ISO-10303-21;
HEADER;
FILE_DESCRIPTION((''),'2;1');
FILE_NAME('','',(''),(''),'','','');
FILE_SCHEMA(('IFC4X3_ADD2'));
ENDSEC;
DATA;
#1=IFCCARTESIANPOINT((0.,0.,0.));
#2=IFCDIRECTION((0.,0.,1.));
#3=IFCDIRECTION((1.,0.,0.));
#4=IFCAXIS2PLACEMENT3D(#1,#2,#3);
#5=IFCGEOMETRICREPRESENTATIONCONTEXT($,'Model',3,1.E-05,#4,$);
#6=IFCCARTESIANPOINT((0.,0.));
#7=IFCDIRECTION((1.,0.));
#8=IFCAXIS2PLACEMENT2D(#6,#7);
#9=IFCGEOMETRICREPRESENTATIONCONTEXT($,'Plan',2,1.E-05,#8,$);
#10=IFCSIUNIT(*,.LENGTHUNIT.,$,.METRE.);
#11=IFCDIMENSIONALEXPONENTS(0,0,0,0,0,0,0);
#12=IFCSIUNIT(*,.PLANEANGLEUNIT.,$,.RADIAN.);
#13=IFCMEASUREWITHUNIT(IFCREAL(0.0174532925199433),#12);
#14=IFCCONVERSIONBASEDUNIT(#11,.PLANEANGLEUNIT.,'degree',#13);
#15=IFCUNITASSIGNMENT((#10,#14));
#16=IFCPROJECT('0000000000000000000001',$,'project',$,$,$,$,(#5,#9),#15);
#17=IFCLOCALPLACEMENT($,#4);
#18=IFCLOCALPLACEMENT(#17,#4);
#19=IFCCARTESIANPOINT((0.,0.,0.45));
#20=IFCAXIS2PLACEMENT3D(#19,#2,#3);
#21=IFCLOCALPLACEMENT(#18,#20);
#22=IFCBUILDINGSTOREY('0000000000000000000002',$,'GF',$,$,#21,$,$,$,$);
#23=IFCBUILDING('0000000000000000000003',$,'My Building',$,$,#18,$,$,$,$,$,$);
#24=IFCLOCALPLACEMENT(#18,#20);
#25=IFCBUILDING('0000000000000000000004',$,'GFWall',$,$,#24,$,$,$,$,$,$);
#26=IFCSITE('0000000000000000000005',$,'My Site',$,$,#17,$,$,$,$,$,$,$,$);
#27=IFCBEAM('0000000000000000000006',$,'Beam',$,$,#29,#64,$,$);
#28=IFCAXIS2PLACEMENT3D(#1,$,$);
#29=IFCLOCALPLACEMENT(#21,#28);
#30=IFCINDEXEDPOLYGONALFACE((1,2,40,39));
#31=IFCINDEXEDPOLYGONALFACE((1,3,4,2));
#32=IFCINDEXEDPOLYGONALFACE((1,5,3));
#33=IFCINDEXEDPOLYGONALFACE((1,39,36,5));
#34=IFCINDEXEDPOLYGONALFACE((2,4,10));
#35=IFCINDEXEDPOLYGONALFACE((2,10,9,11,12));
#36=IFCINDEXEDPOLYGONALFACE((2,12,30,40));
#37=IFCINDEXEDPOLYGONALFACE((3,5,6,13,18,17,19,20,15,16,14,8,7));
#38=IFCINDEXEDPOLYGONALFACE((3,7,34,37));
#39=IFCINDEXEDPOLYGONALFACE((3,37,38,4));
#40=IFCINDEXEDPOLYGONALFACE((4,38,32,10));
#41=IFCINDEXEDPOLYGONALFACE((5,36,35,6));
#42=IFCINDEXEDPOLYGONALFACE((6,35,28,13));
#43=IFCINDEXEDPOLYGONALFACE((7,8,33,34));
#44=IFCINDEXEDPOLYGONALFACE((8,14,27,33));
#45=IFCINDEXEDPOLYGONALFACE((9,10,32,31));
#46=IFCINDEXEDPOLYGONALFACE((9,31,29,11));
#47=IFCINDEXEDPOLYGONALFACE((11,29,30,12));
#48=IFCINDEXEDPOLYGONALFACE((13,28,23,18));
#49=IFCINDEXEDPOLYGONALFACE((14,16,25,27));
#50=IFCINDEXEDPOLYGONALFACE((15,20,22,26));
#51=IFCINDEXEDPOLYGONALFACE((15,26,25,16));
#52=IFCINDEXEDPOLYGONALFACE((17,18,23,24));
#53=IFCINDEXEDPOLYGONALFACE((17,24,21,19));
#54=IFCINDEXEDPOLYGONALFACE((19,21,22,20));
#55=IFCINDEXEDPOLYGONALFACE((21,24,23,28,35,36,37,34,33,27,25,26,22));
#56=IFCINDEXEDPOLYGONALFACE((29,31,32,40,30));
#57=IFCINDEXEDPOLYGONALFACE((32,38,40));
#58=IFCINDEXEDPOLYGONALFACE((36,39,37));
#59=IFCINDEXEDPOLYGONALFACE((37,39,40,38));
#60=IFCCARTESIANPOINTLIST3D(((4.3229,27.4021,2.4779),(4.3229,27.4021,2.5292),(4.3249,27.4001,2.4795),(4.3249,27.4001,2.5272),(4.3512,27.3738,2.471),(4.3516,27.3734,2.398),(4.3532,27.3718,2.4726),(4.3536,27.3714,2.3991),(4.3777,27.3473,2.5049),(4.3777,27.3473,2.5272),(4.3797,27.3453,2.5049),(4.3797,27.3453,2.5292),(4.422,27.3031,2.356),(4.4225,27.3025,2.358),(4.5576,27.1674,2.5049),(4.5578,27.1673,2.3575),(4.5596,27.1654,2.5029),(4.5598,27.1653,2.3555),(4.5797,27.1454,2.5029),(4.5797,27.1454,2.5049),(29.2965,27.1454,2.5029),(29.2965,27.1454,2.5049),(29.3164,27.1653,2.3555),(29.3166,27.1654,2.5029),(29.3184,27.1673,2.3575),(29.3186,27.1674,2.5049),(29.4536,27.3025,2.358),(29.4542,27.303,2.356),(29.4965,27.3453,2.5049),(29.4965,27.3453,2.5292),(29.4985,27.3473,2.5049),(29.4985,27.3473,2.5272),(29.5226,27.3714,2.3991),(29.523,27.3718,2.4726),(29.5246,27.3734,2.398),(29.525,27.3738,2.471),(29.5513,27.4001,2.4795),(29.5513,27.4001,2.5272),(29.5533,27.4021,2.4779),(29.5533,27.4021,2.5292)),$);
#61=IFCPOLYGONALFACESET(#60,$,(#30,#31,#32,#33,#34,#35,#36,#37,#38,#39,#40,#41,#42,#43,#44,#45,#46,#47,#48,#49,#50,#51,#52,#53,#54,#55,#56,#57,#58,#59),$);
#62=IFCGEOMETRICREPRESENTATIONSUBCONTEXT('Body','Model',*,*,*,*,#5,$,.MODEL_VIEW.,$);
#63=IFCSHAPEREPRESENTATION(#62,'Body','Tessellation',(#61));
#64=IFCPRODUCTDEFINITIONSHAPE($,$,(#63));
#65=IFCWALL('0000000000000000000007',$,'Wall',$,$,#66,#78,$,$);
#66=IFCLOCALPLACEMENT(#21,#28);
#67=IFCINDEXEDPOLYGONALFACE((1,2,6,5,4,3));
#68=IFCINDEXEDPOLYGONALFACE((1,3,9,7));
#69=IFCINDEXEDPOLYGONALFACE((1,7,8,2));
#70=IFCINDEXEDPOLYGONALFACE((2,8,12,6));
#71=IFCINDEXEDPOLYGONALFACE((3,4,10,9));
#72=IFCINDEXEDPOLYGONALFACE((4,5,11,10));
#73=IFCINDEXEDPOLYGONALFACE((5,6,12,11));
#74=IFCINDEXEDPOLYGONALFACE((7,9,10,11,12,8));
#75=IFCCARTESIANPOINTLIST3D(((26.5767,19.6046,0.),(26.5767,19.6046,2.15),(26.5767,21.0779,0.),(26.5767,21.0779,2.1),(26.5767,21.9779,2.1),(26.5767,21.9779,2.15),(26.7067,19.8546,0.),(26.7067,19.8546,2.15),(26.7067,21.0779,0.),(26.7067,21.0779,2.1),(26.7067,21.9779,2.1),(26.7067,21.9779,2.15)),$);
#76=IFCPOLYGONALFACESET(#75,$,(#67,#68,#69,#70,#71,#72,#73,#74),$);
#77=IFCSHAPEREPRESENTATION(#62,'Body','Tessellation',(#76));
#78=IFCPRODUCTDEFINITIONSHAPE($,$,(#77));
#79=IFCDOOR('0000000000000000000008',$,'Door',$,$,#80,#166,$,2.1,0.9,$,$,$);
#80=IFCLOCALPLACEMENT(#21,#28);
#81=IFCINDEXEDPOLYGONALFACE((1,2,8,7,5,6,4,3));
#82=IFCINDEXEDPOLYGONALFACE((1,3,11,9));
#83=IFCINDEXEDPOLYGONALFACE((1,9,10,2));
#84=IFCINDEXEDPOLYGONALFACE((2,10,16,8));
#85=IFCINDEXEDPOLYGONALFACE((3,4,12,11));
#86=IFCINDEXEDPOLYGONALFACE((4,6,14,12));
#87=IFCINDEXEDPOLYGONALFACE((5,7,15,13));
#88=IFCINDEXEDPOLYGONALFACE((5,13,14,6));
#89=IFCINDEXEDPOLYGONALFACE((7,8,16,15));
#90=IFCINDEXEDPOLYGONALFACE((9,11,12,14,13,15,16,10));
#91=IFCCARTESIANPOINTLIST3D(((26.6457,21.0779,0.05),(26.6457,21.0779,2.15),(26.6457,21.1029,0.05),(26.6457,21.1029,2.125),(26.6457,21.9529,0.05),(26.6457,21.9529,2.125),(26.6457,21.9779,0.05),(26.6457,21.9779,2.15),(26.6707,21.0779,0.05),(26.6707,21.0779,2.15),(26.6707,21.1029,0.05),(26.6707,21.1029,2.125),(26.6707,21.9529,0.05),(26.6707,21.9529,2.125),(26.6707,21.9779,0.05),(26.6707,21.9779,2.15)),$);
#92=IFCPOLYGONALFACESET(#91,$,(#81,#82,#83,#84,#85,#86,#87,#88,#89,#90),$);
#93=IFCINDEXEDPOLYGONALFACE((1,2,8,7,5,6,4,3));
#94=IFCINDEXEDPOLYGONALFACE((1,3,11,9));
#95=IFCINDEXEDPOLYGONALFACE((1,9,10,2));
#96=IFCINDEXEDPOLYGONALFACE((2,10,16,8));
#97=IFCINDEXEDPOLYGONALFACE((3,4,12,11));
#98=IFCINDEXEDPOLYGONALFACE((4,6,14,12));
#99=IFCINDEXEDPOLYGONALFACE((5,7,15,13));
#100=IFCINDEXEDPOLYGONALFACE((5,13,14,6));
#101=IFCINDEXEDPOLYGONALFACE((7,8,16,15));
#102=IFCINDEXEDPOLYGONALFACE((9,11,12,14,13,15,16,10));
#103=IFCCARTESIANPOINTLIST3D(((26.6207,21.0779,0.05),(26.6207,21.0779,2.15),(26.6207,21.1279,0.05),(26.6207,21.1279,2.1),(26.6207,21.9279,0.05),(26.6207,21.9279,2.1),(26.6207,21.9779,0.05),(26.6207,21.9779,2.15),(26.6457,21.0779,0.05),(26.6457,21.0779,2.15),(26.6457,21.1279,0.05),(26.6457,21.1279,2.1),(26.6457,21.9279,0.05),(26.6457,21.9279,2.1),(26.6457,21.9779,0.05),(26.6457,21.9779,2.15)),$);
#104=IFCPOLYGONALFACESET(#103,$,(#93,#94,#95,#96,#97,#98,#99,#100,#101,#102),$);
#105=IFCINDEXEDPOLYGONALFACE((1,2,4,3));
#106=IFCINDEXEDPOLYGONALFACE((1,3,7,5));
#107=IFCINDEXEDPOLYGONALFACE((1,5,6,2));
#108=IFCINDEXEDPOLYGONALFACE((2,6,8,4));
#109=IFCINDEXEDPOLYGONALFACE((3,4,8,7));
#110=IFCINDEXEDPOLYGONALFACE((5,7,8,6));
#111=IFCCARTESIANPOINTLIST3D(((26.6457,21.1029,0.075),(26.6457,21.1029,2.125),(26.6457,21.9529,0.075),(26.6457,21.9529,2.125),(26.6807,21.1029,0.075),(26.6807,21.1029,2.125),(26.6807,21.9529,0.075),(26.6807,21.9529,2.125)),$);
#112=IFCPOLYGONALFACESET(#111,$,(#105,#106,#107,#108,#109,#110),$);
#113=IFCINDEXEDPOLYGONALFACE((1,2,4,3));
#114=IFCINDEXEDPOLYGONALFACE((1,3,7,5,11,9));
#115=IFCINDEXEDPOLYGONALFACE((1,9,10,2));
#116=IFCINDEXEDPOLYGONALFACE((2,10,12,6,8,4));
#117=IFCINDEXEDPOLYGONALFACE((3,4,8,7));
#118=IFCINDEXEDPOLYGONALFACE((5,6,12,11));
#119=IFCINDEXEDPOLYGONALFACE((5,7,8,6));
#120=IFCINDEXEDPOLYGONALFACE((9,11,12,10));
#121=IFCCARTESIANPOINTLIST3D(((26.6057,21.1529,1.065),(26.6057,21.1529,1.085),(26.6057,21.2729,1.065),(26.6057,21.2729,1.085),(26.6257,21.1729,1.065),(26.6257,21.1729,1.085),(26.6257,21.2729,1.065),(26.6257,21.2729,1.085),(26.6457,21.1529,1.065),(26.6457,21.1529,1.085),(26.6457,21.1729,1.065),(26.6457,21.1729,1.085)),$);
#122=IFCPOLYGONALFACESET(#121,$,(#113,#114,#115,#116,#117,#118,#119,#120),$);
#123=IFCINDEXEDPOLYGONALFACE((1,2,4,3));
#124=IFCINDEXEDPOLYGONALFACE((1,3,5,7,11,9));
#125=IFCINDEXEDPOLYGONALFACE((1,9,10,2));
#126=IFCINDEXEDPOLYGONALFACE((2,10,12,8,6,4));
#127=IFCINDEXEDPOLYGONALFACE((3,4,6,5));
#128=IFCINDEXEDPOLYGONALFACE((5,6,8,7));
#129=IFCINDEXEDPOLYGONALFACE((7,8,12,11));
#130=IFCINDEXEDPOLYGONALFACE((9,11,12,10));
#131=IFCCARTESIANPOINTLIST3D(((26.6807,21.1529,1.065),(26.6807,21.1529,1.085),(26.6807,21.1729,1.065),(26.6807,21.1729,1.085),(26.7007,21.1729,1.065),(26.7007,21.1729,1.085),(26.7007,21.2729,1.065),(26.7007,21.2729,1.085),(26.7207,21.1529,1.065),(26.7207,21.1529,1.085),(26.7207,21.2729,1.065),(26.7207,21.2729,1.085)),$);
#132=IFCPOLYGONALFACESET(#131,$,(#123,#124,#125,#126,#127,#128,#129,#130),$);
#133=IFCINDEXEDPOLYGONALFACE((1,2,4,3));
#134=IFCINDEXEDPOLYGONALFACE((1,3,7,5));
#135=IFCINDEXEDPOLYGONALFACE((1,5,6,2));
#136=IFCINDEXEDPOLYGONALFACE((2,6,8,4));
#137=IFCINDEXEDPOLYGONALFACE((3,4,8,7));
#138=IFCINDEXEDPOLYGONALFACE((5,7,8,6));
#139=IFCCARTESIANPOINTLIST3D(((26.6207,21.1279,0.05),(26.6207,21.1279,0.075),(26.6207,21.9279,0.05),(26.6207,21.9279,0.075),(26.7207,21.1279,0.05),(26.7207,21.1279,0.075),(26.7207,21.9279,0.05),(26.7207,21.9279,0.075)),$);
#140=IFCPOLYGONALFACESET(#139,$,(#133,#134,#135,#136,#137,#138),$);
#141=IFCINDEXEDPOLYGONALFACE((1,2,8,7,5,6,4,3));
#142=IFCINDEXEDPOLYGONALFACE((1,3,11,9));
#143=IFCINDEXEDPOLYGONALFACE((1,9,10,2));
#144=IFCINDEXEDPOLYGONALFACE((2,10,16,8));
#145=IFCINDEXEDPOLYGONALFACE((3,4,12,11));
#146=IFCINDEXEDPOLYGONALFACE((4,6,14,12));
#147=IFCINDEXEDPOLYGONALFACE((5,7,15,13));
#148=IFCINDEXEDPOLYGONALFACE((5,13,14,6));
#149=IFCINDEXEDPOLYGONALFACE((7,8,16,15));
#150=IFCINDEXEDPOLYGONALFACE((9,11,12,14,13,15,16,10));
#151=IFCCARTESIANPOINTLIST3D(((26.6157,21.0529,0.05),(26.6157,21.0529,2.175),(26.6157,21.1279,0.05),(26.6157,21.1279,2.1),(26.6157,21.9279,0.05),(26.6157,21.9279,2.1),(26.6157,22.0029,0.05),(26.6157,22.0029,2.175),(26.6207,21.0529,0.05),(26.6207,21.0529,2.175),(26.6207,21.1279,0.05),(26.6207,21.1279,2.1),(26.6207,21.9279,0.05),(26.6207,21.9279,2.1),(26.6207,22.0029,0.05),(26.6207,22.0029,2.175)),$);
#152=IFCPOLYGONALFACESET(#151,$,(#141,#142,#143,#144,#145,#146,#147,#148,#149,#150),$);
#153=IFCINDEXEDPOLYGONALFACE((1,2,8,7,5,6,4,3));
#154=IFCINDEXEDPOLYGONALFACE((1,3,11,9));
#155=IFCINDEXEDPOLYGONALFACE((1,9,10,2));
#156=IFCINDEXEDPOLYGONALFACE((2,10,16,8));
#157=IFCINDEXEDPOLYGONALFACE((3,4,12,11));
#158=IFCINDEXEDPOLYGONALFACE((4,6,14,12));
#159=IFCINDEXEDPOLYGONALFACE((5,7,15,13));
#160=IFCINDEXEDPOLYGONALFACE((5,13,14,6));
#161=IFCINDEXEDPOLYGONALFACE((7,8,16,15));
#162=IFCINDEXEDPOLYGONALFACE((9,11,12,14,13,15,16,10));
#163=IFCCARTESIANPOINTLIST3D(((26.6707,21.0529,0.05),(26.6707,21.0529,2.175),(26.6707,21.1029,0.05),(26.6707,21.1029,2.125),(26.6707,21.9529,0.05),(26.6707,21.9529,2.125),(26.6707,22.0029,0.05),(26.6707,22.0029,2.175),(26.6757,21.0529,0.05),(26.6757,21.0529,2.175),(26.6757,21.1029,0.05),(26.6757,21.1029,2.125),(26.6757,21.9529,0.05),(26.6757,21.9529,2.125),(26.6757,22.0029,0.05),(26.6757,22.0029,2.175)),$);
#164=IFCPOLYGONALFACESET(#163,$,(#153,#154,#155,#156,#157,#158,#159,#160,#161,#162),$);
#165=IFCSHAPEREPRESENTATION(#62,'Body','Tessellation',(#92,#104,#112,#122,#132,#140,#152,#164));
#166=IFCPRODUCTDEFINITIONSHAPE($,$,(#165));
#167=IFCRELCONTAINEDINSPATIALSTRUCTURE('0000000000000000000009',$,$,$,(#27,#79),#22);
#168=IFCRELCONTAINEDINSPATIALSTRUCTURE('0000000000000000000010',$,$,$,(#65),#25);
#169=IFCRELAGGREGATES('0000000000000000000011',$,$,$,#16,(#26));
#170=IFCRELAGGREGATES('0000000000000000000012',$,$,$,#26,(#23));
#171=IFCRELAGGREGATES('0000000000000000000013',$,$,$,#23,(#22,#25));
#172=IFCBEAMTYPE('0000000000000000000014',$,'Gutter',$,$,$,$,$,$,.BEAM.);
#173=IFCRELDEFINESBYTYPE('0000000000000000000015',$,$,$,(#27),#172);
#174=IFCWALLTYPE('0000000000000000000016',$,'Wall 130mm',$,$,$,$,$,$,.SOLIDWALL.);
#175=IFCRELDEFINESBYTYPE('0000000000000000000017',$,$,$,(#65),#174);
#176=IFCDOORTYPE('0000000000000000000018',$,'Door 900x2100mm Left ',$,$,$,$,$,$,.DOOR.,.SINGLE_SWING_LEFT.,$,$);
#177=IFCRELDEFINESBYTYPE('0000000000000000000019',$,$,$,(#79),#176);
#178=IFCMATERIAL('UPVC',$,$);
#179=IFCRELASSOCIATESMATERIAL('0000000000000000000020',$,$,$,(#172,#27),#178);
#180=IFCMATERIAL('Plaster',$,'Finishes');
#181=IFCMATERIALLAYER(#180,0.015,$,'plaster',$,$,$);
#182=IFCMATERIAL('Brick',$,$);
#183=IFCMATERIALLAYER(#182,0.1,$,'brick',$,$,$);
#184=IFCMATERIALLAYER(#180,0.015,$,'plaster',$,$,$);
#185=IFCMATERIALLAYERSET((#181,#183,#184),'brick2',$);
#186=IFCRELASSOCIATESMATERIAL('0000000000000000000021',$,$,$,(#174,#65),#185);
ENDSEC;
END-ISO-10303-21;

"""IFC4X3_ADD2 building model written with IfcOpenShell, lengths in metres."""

from ifc_helpers import new_model, entity, si_unit, converted_unit, frame, origin_with_axes, origin_2d_with_axis, place, context, subcontext, project, spatial, line, indexed_curve, outline, extrude, clip, halfspace, shape, source, transform, mapped, material, layer, layer_set, layer_usage, material_profile, profile_set, profile_usage, type_object, type_shapes, element, fill, save


model = new_model("IFC4X3_ADD2")

# Units and contexts
model_context = context("Model", 3, precision=1e-05, world=origin_with_axes())
plan_context = context("Plan", 2, precision=1e-05, world=origin_2d_with_axis())
body_context_1 = subcontext(model_context, "Body", "Model", "MODEL_VIEW")
body_context_2 = subcontext(plan_context, "Body", "Plan", "PLAN_VIEW")
ifc_project = project(units=[si_unit("LENGTHUNIT", "METRE"), converted_unit("PLANEANGLEUNIT", "degree", entity("IfcReal", 0.0174532925199433), si_unit("PLANEANGLEUNIT", "RADIAN"), dimensions=[0, 0, 0, 0, 0, 0, 0])], contexts=[model_context, plan_context])

# Site, building, storey
site_placement = place(None, origin_with_axes())
site = spatial("IfcSite", under=ifc_project, at=site_placement, Name="My Site")
building_1_placement = place(site_placement, origin_with_axes())
building_1 = spatial("IfcBuilding", under=site, at=building_1_placement, Name="My Building")
storey_placement = place(building_1_placement, frame((0.0, 0.0, 0.45), z_axis=(0.0, 0.0, 1.0), x_axis=(1.0, 0.0, 0.0)))
storey = spatial("IfcBuildingStorey", under=building_1, at=storey_placement, Name="GF")

# Beam
ifc_material_1 = material(Name="UPVC")
ifc_material_profile_1 = material_profile(ifc_material_1, outline(indexed_curve([(0.0548, 0.1717), (0.002, 0.1717), (0.002, 0.124), (0.0303, 0.1171), (0.0307, 0.0436), (0.0996, 0.0025), (0.2349, 0.002), (0.2347, 0.1494), (0.2567, 0.1494), (0.2567, 0.1474), (0.2367, 0.1474), (0.2369, 0.0), (0.0991, 0.0005), (0.0287, 0.0425), (0.0283, 0.1155), (0.0, 0.1224), (0.0, 0.1737), (0.0568, 0.1737), (0.0568, 0.1494), (0.0548, 0.1494), (0.0548, 0.1717)])))
ifc_profile_set_1 = profile_set([ifc_material_profile_1])
ifc_profile_usage_1 = profile_usage(ifc_profile_set_1, cardinal=5)
beam_type = type_object("IfcBeamType", Name="Gutter", PredefinedType="BEAM", material=ifc_profile_set_1)
beam_placement = place(storey_placement, frame((29.5533, 27.4021, 2.3555), z_axis=(-1.0, 0.000001, 0.0), x_axis=(-0.000001, -1.0, 0.0)))
element("IfcBeam", 1, at=beam_placement, inside=storey, type_object=beam_type, material=ifc_profile_usage_1, Name="Beam", context=body_context_1, shape_type="Clipping", body=[
    clip(clip(extrude(outline(indexed_curve([(0.0548, 0.1717), (0.002, 0.1717), (0.002, 0.124), (0.0303, 0.1171), (0.0307, 0.0436), (0.0996, 0.0025), (0.2349, 0.002), (0.2347, 0.1494), (0.2567, 0.1494), (0.2567, 0.1474), (0.2367, 0.1474), (0.2369, 0.0), (0.0991, 0.0005), (0.0287, 0.0425), (0.0283, 0.1155), (0.0, 0.1224), (0.0, 0.1737), (0.0568, 0.1737), (0.0568, 0.1494), (0.0548, 0.1494), (0.0548, 0.1717)])), origin_with_axes(), (0.0, 0.0, 1.0), 25.2303), halfspace(frame((0.0, -2.6573, 0.0), z_axis=(0.707106, 0.0, -0.707107), x_axis=(0.0, -1.0, 0.0)), False)), halfspace(frame((0.0, -2.6573, 25.2304), z_axis=(0.707107, 0.0, 0.707106), x_axis=(0.0, -1.0, 0.0)), False)),
])

# Shared definitions
building_2_placement = place(building_1_placement, frame((0.0, 0.0, 0.45), z_axis=(0.0, 0.0, 1.0), x_axis=(1.0, 0.0, 0.0)))
building_2 = spatial("IfcBuilding", under=building_1, at=building_2_placement, Name="GFWall")

# Wall, opening, door
ifc_material_2 = material(Name="Plaster", Category="Finishes")
ifc_layer_1 = layer(ifc_material_2, 0.015, Name="plaster")
ifc_material_3 = material(Name="Brick")
ifc_layer_2 = layer(ifc_material_3, 0.1, Name="brick")
ifc_layer_3 = layer(ifc_material_2, 0.015, Name="plaster")
ifc_layer_set_1 = layer_set([ifc_layer_1, ifc_layer_2, ifc_layer_3], Name="brick2")
ifc_layer_usage_1 = layer_usage(ifc_layer_set_1, "AXIS2", "POSITIVE", 0.0)
wall_type = type_object("IfcWallType", Name="Wall 130mm", PredefinedType="SOLIDWALL", material=ifc_layer_set_1)
wall_placement = place(building_2_placement, frame((26.7067, 19.6046, 0.0), z_axis=(0.0, 0.0, 1.0), x_axis=(0.0, 1.0, 0.0)))
wall = element("IfcWall", 2, at=wall_placement, inside=building_2, type_object=wall_type, material=ifc_layer_usage_1, Name="Wall", context=body_context_1, shape_type="SweptSolid", body=[
    extrude(outline(indexed_curve([(0.25, 0.0), (0.0, 0.13), (2.3733, 0.13), (2.3733, 0.0)], segments=[line(1, 2, 3, 4, 1)])), origin_with_axes(), (0.0, 0.0, 1.0), 2.15),
])
shared_shape_1 = source(origin_with_axes(), body_context_1, "Body", "SweptSolid", [
    extrude(outline(indexed_curve([(0.0, 0.0), (0.9, 0.0), (0.9, 2.1), (0.0, 2.1)], segments=[line(1, 2, 3, 4, 1)])), frame((0.0, -0.6, 0.0), z_axis=(0.0, -1.0, 0.0), x_axis=(1.0, 0.0, 0.0)), (0.0, 0.0, -1.0), 1.2),
])
opening_placement = place(wall_placement, frame((2.3733, 0.071, 0.0), z_axis=(0.0, 0.0, 1.0), x_axis=(-1.0, 0.0, 0.0)))
opening = element("IfcOpeningElement", 3, at=opening_placement, cuts=wall, PredefinedType="OPENING", context=body_context_1, shape_type="MappedRepresentation", body=[
    mapped(shared_shape_1, transform((0.0, 0.0, 0.0), x_axis=(1.0, 0.0, 0.0), y_axis=(0.0, 1.0, 0.0), z_axis=(0.0, 0.0, 1.0), scale=1.0)),
])
door_type = type_object("IfcDoorType", Name="Door 900x2100mm Left ", OperationType="SINGLE_SWING_LEFT", PredefinedType="DOOR")
shared_shape_2 = source(origin_with_axes(), body_context_1, "Body", "SweptSolid", [
    extrude(outline(indexed_curve([(0.0, 0.0), (0.0, 2.1), (0.9, 2.1), (0.9, 0.0), (0.875, 0.0), (0.875, 2.075), (0.025, 2.075), (0.025, 0.0)], segments=[line(1, 2, 3, 4, 5, 6, 7, 8, 1)])), frame((0.0, 0.025, 0.0), z_axis=(0.0, -1.0, 0.0), x_axis=(1.0, 0.0, 0.0)), (0.0, 0.0, -1.0), 0.025),
    extrude(outline(indexed_curve([(0.0, 0.0), (0.0, 2.1), (0.9, 2.1), (0.9, 0.0), (0.85, 0.0), (0.85, 2.05), (0.05, 2.05), (0.05, 0.0)], segments=[line(1, 2, 3, 4, 5, 6, 7, 8, 1)])), frame((0.0, 0.0, 0.0), z_axis=(0.0, -1.0, 0.0), x_axis=(1.0, 0.0, 0.0)), (0.0, 0.0, -1.0), 0.025),
    extrude(outline(indexed_curve([(0.0, 0.0), (0.85, 0.0), (0.85, 0.035), (0.0, 0.035)], segments=[line(1, 2, 3, 4, 1)])), frame((0.025, 0.025, 0.025), z_axis=(0.0, 0.0, 1.0), x_axis=(1.0, 0.0, 0.0)), (0.0, 0.0, 1.0), 2.05),
    extrude(outline(indexed_curve([(0.0, 0.0), (0.0, -0.04), (-0.12, -0.04), (-0.12, -0.02), (-0.02, -0.02), (-0.02, 0.0)], segments=[line(1, 2, 3, 4, 5, 6, 1)])), frame((0.825, 0.025, 1.015), z_axis=(0.0, 0.0, 1.0), x_axis=(1.0, 0.0, 0.0)), (0.0, 0.0, 1.0), 0.02),
    extrude(outline(indexed_curve([(0.0, 0.0), (0.0, 0.04), (-0.12, 0.04), (-0.12, 0.02), (-0.02, 0.02), (-0.02, 0.0)], segments=[line(1, 2, 3, 4, 5, 6, 1)])), frame((0.825, 0.06, 1.015), z_axis=(0.0, 0.0, 1.0), x_axis=(1.0, 0.0, 0.0)), (0.0, 0.0, 1.0), 0.02),
    extrude(outline(indexed_curve([(0.0, 0.0), (0.8, 0.0), (0.8, 0.1), (0.0, 0.1)], segments=[line(1, 2, 3, 4, 1)])), frame((0.05, 0.0, 0.0), z_axis=(0.0, 0.0, 1.0), x_axis=(1.0, 0.0, 0.0)), (0.0, 0.0, 1.0), 0.025),
    extrude(outline(indexed_curve([(0.0, 0.0), (0.0, 2.125), (0.95, 2.125), (0.95, 0.0), (0.875, 0.0), (0.875, 2.05), (0.075, 2.05), (0.075, 0.0)], segments=[line(1, 2, 3, 4, 5, 6, 7, 8, 1)])), frame((-0.025, -0.005, 0.0), z_axis=(0.0, -1.0, 0.0), x_axis=(1.0, 0.0, 0.0)), (0.0, 0.0, -1.0), 0.005),
    extrude(outline(indexed_curve([(0.0, 0.0), (0.0, 2.125), (0.95, 2.125), (0.95, 0.0), (0.9, 0.0), (0.9, 2.075), (0.05, 2.075), (0.05, 0.0)], segments=[line(1, 2, 3, 4, 5, 6, 7, 8, 1)])), frame((-0.025, 0.05, 0.0), z_axis=(0.0, -1.0, 0.0), x_axis=(1.0, 0.0, 0.0)), (0.0, 0.0, -1.0), 0.005),
])
shared_shape_3 = source(origin_with_axes(), body_context_2, "Body", "Curve2D", [
    entity("IfcIndexedPolyCurve", entity("IfcCartesianPointList2D", [[0.0, 0.0], [0.0, 0.05], [0.025, 0.05], [0.025, 0.025], [0.05, 0.025], [0.05, 0.0]]), [entity("IfcLineIndex", [1, 2, 3, 4, 5, 6, 1])]),
    entity("IfcIndexedPolyCurve", entity("IfcCartesianPointList2D", [[0.9, 0.0], [0.9, 0.05], [0.875, 0.05], [0.875, 0.025], [0.85, 0.025], [0.85, 0.0]]), [entity("IfcLineIndex", [1, 2, 3, 4, 5, 6, 1])]),
    entity("IfcTrimmedCurve", entity("IfcEllipse", entity("IfcAxis2Placement2D", entity("IfcCartesianPoint", [0.06, 0.05]), entity("IfcDirection", [1.0, 0.0])), 0.815, 0.85), [entity("IfcCartesianPoint", [0.875, 0.05])], [entity("IfcCartesianPoint", [0.06, 0.9])], True, "CARTESIAN"),
    entity("IfcIndexedPolyCurve", entity("IfcCartesianPointList2D", [[0.025, 0.05], [0.06, 0.05], [0.06, 0.9], [0.025, 0.9]]), [entity("IfcLineIndex", [1, 2, 3, 4, 1])]),
])
type_shapes(door_type, [shared_shape_2, shared_shape_3])
door_placement = place(opening_placement, frame((0.0, -0.015, 0.05), z_axis=(0.0, 0.0, 1.0), x_axis=(1.0, 0.0, 0.0)))
door = element("IfcDoor", 4, at=door_placement, inside=storey, type_object=door_type, Name="Door", OverallHeight=2.1, OverallWidth=0.9, shapes=[
    shape(body_context_1, "Body", "MappedRepresentation", [mapped(shared_shape_2, transform((0.0, 0.0, 0.0), x_axis=(1.0, 0.0, 0.0), y_axis=(0.0, 1.0, 0.0), z_axis=(0.0, 0.0, 1.0), scale=1.0))]),
    shape(body_context_2, "Body", "MappedRepresentation", [mapped(shared_shape_3, transform((0.0, 0.0, 0.0), x_axis=(1.0, 0.0, 0.0), y_axis=(0.0, 1.0, 0.0), z_axis=(0.0, 0.0, 1.0), scale=1.0))]),
])
fill(opening, door)

save(model, "model.ifc")
